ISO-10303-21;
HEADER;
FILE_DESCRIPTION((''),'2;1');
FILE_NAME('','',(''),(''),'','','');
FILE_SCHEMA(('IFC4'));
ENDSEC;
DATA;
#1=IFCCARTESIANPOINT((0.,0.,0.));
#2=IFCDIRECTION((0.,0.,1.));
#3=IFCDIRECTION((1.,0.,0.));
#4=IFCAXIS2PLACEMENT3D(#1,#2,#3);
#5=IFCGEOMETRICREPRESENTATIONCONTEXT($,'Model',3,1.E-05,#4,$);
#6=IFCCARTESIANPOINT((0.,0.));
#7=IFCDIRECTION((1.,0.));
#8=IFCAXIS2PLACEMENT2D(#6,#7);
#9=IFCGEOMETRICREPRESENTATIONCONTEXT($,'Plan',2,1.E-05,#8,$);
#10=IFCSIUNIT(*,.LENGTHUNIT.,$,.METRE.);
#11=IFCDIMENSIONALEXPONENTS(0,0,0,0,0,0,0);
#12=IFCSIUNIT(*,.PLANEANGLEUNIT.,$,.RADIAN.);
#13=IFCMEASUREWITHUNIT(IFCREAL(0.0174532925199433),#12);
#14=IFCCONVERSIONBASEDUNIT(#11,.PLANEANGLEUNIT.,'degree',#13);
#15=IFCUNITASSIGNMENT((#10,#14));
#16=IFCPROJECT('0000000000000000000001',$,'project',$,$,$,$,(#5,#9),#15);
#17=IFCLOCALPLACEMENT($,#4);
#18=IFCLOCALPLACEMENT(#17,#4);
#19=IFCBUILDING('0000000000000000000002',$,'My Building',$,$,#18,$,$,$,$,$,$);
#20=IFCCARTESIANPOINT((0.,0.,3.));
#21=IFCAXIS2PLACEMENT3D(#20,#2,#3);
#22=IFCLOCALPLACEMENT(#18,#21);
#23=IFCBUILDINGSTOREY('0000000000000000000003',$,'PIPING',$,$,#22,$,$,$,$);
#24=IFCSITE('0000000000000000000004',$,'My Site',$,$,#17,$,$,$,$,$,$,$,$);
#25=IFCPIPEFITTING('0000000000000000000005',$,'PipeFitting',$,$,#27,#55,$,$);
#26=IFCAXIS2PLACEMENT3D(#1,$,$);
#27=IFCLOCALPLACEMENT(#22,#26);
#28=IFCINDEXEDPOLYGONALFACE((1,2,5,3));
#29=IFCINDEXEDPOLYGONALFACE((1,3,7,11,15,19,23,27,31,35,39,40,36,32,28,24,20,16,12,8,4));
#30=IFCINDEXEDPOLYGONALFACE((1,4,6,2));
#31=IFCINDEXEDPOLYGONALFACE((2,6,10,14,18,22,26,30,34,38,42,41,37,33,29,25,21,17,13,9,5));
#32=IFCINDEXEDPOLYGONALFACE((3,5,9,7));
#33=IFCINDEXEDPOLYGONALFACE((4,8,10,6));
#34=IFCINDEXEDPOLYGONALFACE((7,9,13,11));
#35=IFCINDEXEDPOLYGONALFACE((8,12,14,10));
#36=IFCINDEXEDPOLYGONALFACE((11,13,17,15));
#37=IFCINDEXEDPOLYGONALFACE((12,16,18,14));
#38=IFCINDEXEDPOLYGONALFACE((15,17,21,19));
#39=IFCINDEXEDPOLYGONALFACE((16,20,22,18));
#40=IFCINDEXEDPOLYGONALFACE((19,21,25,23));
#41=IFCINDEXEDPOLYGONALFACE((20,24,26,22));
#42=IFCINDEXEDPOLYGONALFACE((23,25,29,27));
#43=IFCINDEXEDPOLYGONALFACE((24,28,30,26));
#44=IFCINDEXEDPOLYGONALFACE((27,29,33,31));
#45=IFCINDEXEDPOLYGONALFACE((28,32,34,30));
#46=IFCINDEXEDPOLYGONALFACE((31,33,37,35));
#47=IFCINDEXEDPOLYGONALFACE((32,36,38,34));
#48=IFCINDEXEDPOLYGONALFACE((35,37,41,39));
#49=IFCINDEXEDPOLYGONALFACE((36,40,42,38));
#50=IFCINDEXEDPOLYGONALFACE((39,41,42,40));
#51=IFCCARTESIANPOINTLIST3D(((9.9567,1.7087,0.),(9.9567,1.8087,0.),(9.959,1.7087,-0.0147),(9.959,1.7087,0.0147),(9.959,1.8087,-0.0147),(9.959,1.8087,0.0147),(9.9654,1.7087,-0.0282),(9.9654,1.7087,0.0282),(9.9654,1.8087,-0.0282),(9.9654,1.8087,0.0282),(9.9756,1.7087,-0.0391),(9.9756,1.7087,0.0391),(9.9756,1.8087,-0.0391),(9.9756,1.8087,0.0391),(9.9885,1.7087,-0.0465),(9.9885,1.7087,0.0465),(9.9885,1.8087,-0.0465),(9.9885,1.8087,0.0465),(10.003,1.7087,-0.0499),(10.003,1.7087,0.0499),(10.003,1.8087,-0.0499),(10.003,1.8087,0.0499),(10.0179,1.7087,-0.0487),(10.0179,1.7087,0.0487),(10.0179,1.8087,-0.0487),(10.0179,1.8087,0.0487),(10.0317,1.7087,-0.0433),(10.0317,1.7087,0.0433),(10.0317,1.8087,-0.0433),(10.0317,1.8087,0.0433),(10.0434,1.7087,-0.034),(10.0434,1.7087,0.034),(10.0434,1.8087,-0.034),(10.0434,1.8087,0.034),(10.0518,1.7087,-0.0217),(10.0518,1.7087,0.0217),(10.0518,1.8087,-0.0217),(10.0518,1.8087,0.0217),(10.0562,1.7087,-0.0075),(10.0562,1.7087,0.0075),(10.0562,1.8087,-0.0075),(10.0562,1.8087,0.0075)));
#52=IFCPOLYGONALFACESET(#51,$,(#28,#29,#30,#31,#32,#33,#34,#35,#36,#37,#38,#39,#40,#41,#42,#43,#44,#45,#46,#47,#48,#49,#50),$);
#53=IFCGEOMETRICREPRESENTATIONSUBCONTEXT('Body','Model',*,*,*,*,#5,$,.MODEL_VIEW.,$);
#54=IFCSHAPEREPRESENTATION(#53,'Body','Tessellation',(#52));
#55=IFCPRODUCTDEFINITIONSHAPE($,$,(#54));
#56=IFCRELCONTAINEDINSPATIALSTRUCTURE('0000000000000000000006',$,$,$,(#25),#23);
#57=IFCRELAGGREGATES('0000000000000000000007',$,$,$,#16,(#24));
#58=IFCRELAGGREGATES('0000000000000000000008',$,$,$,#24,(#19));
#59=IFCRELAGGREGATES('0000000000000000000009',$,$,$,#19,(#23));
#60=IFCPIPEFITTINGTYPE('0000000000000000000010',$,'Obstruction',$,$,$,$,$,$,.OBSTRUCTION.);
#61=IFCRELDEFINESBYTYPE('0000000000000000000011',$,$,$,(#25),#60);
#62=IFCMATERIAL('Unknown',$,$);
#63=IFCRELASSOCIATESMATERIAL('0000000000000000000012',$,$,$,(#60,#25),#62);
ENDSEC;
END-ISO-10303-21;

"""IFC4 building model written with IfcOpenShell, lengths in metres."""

from ifc_helpers import new_model, entity, si_unit, converted_unit, frame, origin_with_axes, origin_2d_with_axis, place, context, subcontext, project, spatial, circle, extrude, material, material_profile, profile_set, profile_usage, type_object, element, save


model = new_model("IFC4")

# Units and contexts
model_context = context("Model", 3, precision=1e-05, world=origin_with_axes())
plan_context = context("Plan", 2, precision=1e-05, world=origin_2d_with_axis())
body_context = subcontext(model_context, "Body", "Model", "MODEL_VIEW")
ifc_project = project(units=[si_unit("LENGTHUNIT", "METRE"), converted_unit("PLANEANGLEUNIT", "degree", entity("IfcReal", 0.0174532925199433), si_unit("PLANEANGLEUNIT", "RADIAN"), dimensions=[0, 0, 0, 0, 0, 0, 0])], contexts=[model_context, plan_context])

# Site, building, storey
site_placement = place(None, origin_with_axes())
site = spatial("IfcSite", under=ifc_project, at=site_placement, Name="My Site")
building_placement = place(site_placement, origin_with_axes())
building = spatial("IfcBuilding", under=site, at=building_placement, Name="My Building")
storey_placement = place(building_placement, frame((0.0, 0.0, 3.0), z_axis=(0.0, 0.0, 1.0), x_axis=(1.0, 0.0, 0.0)))
storey = spatial("IfcBuildingStorey", under=building, at=storey_placement, Name="PIPING")

# Shared definitions
ifc_material = material(Name="Unknown")

# Pipe fitting
ifc_material_profile_1 = material_profile(ifc_material, circle(Radius=0.05))
ifc_profile_set_1 = profile_set([ifc_material_profile_1])
ifc_profile_usage_1 = profile_usage(ifc_profile_set_1, cardinal=5)
pipe_fitting_type_1 = type_object("IfcPipeFittingType", Name="Obstruction", PredefinedType="OBSTRUCTION", material=ifc_profile_set_1)
pipe_fitting_1_placement = place(storey_placement, frame((10.0067, 1.7087, 0.0), z_axis=(0.0, 1.0, 0.0), x_axis=(-1.0, 0.0, 0.0)))
element("IfcPipeFitting", 1, at=pipe_fitting_1_placement, inside=storey, type_object=pipe_fitting_type_1, material=ifc_profile_usage_1, Name="PipeFitting", context=body_context, shape_type="SweptSolid", body=[
    extrude(circle(Radius=0.05), origin_with_axes(), (0.0, 0.0, 1.0), 0.1),
])

save(model, "model.ifc")
